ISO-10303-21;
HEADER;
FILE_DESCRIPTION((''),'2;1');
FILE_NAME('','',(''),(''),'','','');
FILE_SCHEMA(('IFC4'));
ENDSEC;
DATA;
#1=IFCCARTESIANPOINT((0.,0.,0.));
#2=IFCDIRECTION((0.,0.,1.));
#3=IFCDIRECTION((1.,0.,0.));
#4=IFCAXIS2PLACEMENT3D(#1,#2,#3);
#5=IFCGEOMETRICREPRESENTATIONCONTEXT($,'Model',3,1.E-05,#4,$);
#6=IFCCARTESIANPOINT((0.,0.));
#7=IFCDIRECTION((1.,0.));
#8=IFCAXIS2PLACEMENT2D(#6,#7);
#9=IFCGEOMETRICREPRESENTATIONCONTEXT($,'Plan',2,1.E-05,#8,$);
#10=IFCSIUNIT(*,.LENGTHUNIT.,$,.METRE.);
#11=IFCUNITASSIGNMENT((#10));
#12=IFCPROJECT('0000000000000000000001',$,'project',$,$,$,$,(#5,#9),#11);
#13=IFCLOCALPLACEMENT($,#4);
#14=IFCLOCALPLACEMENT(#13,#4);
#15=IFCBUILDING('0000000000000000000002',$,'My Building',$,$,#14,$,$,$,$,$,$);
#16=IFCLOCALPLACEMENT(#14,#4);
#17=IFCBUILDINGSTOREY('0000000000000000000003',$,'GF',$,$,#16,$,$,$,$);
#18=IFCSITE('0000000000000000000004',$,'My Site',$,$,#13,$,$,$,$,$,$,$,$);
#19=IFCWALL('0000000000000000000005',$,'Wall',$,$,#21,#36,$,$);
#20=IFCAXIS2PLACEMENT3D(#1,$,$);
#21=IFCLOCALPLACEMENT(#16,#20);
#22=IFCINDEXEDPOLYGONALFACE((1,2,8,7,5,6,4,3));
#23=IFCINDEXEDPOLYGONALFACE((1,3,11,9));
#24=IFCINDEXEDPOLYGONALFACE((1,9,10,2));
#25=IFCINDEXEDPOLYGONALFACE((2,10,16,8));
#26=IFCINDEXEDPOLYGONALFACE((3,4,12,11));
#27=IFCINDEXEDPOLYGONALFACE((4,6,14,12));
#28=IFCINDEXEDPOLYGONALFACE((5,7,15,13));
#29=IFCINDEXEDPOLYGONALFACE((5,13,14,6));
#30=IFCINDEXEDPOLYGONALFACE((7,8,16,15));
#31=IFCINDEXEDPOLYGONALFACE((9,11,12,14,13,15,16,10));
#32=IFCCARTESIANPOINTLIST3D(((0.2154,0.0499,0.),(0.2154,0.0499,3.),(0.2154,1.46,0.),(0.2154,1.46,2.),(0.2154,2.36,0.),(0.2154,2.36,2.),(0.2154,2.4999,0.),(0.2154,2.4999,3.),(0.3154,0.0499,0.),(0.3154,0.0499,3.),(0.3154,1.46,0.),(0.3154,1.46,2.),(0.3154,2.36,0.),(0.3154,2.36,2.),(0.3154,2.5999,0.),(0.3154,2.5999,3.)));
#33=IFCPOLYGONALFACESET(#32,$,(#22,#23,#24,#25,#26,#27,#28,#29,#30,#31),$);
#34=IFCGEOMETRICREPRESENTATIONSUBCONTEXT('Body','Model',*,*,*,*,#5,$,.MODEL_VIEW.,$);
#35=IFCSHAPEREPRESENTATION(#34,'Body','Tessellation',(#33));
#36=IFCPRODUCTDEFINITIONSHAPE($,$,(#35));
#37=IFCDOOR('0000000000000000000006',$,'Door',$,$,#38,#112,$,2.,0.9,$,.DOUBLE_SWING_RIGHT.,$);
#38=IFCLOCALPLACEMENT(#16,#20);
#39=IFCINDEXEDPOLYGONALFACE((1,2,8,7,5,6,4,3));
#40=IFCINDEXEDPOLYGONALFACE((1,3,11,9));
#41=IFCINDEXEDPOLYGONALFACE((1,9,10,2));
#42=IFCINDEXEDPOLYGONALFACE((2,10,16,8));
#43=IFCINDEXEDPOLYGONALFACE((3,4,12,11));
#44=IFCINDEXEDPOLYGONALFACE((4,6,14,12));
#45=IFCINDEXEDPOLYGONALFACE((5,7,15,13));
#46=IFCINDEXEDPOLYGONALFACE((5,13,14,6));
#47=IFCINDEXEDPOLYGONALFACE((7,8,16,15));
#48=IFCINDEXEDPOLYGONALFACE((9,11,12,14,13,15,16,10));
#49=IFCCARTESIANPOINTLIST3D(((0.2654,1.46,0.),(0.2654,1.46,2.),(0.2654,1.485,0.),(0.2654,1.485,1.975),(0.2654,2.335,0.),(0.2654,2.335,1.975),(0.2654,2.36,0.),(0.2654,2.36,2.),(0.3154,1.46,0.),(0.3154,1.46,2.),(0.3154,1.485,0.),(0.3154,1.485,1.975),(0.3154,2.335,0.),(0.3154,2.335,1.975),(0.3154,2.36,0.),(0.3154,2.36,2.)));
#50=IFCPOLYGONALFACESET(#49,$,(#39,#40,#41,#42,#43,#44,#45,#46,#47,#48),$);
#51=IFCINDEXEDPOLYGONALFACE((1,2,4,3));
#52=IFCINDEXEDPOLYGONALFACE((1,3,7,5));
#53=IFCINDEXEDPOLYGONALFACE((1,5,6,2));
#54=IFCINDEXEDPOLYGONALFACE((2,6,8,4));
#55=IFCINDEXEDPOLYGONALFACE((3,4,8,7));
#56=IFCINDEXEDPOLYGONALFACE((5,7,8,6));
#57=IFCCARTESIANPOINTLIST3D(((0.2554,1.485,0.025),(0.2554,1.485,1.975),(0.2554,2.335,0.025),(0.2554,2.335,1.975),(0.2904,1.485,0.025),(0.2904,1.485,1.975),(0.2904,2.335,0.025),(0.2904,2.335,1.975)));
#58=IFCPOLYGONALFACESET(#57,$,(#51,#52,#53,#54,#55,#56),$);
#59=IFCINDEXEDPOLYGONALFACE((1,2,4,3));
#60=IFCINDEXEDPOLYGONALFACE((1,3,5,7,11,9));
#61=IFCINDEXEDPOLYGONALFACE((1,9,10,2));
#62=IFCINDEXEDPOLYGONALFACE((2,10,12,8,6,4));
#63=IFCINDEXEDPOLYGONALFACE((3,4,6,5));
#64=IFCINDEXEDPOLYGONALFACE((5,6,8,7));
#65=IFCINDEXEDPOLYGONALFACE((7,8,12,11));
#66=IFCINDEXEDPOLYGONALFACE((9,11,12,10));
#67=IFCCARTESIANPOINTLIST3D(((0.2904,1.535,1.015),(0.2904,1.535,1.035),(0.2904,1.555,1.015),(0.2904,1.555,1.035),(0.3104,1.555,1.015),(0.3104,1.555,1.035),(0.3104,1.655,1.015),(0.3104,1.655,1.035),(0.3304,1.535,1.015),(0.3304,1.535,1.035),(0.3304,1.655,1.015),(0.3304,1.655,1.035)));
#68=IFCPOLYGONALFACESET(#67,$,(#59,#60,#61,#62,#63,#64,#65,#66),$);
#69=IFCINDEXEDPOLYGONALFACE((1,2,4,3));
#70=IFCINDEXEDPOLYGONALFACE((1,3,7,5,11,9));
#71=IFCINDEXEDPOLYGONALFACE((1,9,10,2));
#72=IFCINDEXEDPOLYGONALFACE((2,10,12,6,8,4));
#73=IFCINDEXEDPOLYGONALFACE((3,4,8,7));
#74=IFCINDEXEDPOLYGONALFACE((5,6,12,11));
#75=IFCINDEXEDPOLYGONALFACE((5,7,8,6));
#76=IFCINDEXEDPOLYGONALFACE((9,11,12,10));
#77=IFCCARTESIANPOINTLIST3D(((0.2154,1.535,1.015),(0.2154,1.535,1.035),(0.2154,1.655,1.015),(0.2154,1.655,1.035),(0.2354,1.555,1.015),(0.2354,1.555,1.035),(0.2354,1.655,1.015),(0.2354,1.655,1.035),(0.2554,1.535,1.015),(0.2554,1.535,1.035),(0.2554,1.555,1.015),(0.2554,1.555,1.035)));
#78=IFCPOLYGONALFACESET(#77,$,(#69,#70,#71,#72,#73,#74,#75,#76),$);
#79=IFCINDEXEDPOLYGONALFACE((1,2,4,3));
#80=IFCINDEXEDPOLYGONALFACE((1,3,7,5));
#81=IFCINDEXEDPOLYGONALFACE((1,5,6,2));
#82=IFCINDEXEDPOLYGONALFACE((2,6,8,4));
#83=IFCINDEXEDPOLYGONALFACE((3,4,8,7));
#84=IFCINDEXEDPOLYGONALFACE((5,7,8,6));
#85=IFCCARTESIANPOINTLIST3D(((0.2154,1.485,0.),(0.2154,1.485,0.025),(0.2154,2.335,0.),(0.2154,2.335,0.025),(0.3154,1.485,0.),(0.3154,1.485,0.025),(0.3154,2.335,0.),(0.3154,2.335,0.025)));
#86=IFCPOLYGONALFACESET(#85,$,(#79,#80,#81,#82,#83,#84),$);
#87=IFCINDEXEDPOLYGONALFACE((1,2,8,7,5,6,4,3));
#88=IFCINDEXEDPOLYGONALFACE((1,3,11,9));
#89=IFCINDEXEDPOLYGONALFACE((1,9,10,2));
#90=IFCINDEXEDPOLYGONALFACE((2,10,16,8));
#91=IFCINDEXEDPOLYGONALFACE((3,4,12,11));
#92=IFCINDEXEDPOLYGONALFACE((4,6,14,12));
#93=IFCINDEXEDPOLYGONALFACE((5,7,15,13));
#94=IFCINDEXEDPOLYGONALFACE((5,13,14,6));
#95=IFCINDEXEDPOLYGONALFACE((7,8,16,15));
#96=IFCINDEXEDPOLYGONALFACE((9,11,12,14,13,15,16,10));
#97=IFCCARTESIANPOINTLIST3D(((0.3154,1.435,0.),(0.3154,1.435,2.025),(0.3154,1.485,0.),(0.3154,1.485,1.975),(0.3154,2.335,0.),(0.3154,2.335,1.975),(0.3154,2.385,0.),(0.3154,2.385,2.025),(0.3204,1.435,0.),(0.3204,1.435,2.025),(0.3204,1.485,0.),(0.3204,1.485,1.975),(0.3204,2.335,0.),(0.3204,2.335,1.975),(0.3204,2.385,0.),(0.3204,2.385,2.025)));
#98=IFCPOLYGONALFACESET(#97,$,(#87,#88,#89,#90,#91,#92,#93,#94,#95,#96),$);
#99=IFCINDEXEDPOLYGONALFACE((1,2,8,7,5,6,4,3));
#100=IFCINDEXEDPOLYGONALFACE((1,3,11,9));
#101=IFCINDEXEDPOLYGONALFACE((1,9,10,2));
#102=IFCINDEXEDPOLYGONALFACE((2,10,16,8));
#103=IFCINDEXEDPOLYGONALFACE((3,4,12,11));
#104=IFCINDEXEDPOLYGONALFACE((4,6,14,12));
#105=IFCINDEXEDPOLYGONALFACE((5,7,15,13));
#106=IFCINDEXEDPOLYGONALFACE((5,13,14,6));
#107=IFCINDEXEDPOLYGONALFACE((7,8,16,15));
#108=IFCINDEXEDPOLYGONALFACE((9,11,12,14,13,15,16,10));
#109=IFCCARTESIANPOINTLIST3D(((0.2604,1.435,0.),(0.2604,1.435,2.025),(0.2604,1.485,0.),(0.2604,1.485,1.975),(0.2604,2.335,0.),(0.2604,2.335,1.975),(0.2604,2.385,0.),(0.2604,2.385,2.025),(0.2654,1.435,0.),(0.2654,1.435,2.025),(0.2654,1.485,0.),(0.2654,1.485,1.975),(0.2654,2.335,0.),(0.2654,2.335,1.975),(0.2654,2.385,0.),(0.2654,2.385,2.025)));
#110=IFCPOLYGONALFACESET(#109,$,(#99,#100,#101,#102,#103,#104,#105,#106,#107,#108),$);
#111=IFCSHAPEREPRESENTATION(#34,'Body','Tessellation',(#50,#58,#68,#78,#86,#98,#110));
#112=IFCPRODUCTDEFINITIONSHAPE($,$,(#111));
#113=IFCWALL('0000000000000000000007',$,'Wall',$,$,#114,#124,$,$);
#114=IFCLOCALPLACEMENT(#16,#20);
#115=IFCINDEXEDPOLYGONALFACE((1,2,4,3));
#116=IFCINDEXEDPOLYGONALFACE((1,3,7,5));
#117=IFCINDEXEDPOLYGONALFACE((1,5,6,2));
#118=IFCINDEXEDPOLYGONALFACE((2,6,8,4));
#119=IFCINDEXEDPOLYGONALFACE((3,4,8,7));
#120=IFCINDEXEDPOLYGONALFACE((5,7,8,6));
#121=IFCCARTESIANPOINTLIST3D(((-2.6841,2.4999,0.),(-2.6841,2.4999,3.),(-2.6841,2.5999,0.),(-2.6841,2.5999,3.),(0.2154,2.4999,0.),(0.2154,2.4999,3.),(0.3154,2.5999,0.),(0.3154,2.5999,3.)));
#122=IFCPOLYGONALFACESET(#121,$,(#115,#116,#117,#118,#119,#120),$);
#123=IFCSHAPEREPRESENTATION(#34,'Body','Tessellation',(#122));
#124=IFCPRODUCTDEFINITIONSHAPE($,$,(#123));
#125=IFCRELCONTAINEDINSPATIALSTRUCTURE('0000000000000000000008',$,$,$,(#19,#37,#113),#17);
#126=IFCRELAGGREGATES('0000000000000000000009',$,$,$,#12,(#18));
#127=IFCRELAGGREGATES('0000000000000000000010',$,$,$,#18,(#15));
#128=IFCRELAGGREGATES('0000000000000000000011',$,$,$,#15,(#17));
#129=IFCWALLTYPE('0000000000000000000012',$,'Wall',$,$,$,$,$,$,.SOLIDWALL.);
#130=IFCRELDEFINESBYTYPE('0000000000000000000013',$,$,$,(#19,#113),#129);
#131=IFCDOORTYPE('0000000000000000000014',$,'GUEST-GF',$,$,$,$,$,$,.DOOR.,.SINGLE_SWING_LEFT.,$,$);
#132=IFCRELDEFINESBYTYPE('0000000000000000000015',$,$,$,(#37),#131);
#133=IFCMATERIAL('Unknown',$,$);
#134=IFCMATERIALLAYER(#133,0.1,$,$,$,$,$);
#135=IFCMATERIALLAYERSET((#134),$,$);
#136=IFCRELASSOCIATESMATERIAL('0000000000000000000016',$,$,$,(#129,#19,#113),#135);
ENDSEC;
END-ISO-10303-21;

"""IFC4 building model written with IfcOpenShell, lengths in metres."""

from ifc_helpers import new_model, entity, si_unit, frame, origin_with_axes, origin_2d_with_axis, place, context, subcontext, project, spatial, line, indexed_curve, outline, extrude, shape, source, transform, mapped, material, layer, layer_set, layer_usage, type_object, type_shapes, element, fill, save


model = new_model("IFC4")

# Units and contexts
model_context = context("Model", 3, precision=1e-05, world=origin_with_axes())
plan_context = context("Plan", 2, precision=1e-05, world=origin_2d_with_axis())
body_context_1 = subcontext(model_context, "Body", "Model", "MODEL_VIEW")
body_context_2 = subcontext(plan_context, "Body", "Plan", "PLAN_VIEW")
ifc_project = project(units=[si_unit("LENGTHUNIT", "METRE")], contexts=[model_context, plan_context])

# Site, building, storey
site_placement = place(None, origin_with_axes())
site = spatial("IfcSite", under=ifc_project, at=site_placement, Name="My Site")
building_placement = place(site_placement, origin_with_axes())
building = spatial("IfcBuilding", under=site, at=building_placement, Name="My Building")
storey_placement = place(building_placement, origin_with_axes())
storey = spatial("IfcBuildingStorey", under=building, at=storey_placement, Name="GF")

# Shared definitions
ifc_material_1 = material(Name="Unknown")

# Shared definitions
ifc_layer_1 = layer(ifc_material_1, 0.1)
ifc_layer_set_1 = layer_set([ifc_layer_1])
wall_type = type_object("IfcWallType", Name="Wall", PredefinedType="SOLIDWALL", material=ifc_layer_set_1)

# Wall, opening, door
ifc_layer_usage_1 = layer_usage(ifc_layer_set_1, "AXIS2", "POSITIVE", 0.0)
wall_1_placement = place(storey_placement, frame((0.3154, 0.0499, 0.0), z_axis=(0.0, 0.0, 1.0), x_axis=(0.0, 1.0, 0.0)))
wall_1 = element("IfcWall", 1, at=wall_1_placement, inside=storey, type_object=wall_type, material=ifc_layer_usage_1, Name="Wall", context=body_context_1, shape_type="SweptSolid", body=[
    extrude(outline(indexed_curve([(0.0, 0.0), (0.0, 0.1), (2.45, 0.1), (2.55, 0.0)], segments=[line(1, 2, 3, 4, 1)])), origin_with_axes(), (0.0, 0.0, 1.0), 3.0),
])
shared_shape_1 = source(origin_with_axes(), body_context_1, "Body", "SweptSolid", [
    extrude(outline(indexed_curve([(0.0, 0.0), (0.9, 0.0), (0.9, 2.0), (0.0, 2.0)], segments=[line(1, 2, 3, 4, 1)])), frame((0.0, -0.6, 0.0), z_axis=(0.0, -1.0, 0.0), x_axis=(1.0, 0.0, 0.0)), (0.0, 0.0, -1.0), 1.2),
])
opening_1_placement = place(wall_1_placement, frame((1.4101, 0.0, 0.0), z_axis=(0.0, 0.0, 1.0), x_axis=(1.0, 0.0, 0.0)))
opening_1 = element("IfcOpeningElement", 2, at=opening_1_placement, cuts=wall_1, PredefinedType="OPENING", context=body_context_1, shape_type="MappedRepresentation", body=[
    mapped(shared_shape_1, transform((0.0, 0.0, 0.0), x_axis=(1.0, 0.0, 0.0), y_axis=(0.0, 1.0, 0.0), z_axis=(0.0, 0.0, 1.0), scale=1.0)),
])
door_type_1 = type_object("IfcDoorType", Name="GUEST-GF", OperationType="SINGLE_SWING_LEFT", PredefinedType="DOOR")
shared_shape_2 = source(origin_with_axes(), body_context_1, "Body", "SweptSolid", [
    extrude(outline(indexed_curve([(0.0, 0.0), (0.0, 2.0), (0.9, 2.0), (0.9, 0.0), (0.875, 0.0), (0.875, 1.975), (0.025, 1.975), (0.025, 0.0)], segments=[line(1, 2, 3, 4, 5, 6, 7, 8, 1)])), frame((0.0, 0.0, 0.0), z_axis=(0.0, -1.0, 0.0), x_axis=(1.0, 0.0, 0.0)), (0.0, 0.0, -1.0), 0.05),
    extrude(outline(indexed_curve([(0.0, 0.0), (0.85, 0.0), (0.85, 0.035), (0.0, 0.035)], segments=[line(1, 2, 3, 4, 1)])), frame((0.025, 0.025, 0.025), z_axis=(0.0, 0.0, 1.0), x_axis=(1.0, 0.0, 0.0)), (0.0, 0.0, 1.0), 1.95),
    extrude(outline(indexed_curve([(0.0, 0.0), (0.0, -0.04), (0.12, -0.04), (0.12, -0.02), (0.02, -0.02), (0.02, 0.0)], segments=[line(1, 2, 3, 4, 5, 6, 1)])), frame((0.075, 0.025, 1.015), z_axis=(0.0, 0.0, 1.0), x_axis=(1.0, 0.0, 0.0)), (0.0, 0.0, 1.0), 0.02),
    extrude(outline(indexed_curve([(0.0, 0.0), (0.0, 0.04), (0.12, 0.04), (0.12, 0.02), (0.02, 0.02), (0.02, 0.0)], segments=[line(1, 2, 3, 4, 5, 6, 1)])), frame((0.075, 0.06, 1.015), z_axis=(0.0, 0.0, 1.0), x_axis=(1.0, 0.0, 0.0)), (0.0, 0.0, 1.0), 0.02),
    extrude(outline(indexed_curve([(0.0, 0.0), (0.85, 0.0), (0.85, 0.1), (0.0, 0.1)], segments=[line(1, 2, 3, 4, 1)])), frame((0.025, 0.0, 0.0), z_axis=(0.0, 0.0, 1.0), x_axis=(1.0, 0.0, 0.0)), (0.0, 0.0, 1.0), 0.025),
    extrude(outline(indexed_curve([(0.0, 0.0), (0.0, 2.025), (0.95, 2.025), (0.95, 0.0), (0.9, 0.0), (0.9, 1.975), (0.05, 1.975), (0.05, 0.0)], segments=[line(1, 2, 3, 4, 5, 6, 7, 8, 1)])), frame((-0.025, -0.005, 0.0), z_axis=(0.0, -1.0, 0.0), x_axis=(1.0, 0.0, 0.0)), (0.0, 0.0, -1.0), 0.005),
    extrude(outline(indexed_curve([(0.0, 0.0), (0.0, 2.025), (0.95, 2.025), (0.95, 0.0), (0.9, 0.0), (0.9, 1.975), (0.05, 1.975), (0.05, 0.0)], segments=[line(1, 2, 3, 4, 5, 6, 7, 8, 1)])), frame((-0.025, 0.05, 0.0), z_axis=(0.0, -1.0, 0.0), x_axis=(1.0, 0.0, 0.0)), (0.0, 0.0, -1.0), 0.005),
])
shared_shape_3 = source(origin_with_axes(), body_context_2, "Body", "Curve2D", [
    entity("IfcIndexedPolyCurve", entity("IfcCartesianPointList2D", [[0.0, 0.0], [0.025, 0.0], [0.025, 0.05], [0.0, 0.05]]), [entity("IfcLineIndex", [1, 2, 3, 4, 1])]),
    entity("IfcIndexedPolyCurve", entity("IfcCartesianPointList2D", [[0.9, 0.0], [0.875, 0.0], [0.875, 0.05], [0.9, 0.05]]), [entity("IfcLineIndex", [1, 2, 3, 4, 1])]),
    entity("IfcIndexedPolyCurve", entity("IfcCartesianPointList2D", [[0.875, 0.05], [0.875, -0.8], [0.84, -0.8]])),
    entity("IfcTrimmedCurve", entity("IfcEllipse", entity("IfcAxis2Placement2D", entity("IfcCartesianPoint", [0.84, 0.05]), entity("IfcDirection", [1.0, 0.0])), 0.815, 0.85), [entity("IfcCartesianPoint", [0.84, 0.9])], [entity("IfcCartesianPoint", [0.84, -0.8])], True, "CARTESIAN"),
    entity("IfcIndexedPolyCurve", entity("IfcCartesianPointList2D", [[0.875, 0.05], [0.84, 0.05], [0.84, 0.9], [0.875, 0.9]]), [entity("IfcLineIndex", [1, 2, 3, 4, 1])]),
])
type_shapes(door_type_1, [shared_shape_2, shared_shape_3])
door_1_placement = place(opening_1_placement, frame((0.0, 0.0, 0.0), z_axis=(0.0, 0.0, 1.0), x_axis=(1.0, 0.0, 0.0)))
door_1 = element("IfcDoor", 3, at=door_1_placement, inside=storey, type_object=door_type_1, Name="Door", OperationType="DOUBLE_SWING_RIGHT", OverallHeight=2.0, OverallWidth=0.9, shapes=[
    shape(body_context_1, "Body", "MappedRepresentation", [mapped(shared_shape_2, transform((0.0, 0.0, 0.0), x_axis=(1.0, 0.0, 0.0), y_axis=(0.0, 1.0, 0.0), z_axis=(0.0, 0.0, 1.0), scale=1.0))]),
    shape(body_context_2, "Body", "MappedRepresentation", [mapped(shared_shape_3, transform((0.0, 0.0, 0.0), x_axis=(1.0, 0.0, 0.0), y_axis=(0.0, 1.0, 0.0), z_axis=(0.0, 0.0, 1.0), scale=1.0))]),
])
fill(opening_1, door_1)

# Wall
ifc_layer_usage_2 = layer_usage(ifc_layer_set_1, "AXIS2", "POSITIVE", 0.0)
wall_2_placement = place(storey_placement, frame((0.3154, 2.5999, 0.0), z_axis=(0.0, 0.0, 1.0), x_axis=(-1.0, 0.0, 0.0)))
element("IfcWall", 4, at=wall_2_placement, inside=storey, type_object=wall_type, material=ifc_layer_usage_2, Name="Wall", context=body_context_1, shape_type="SweptSolid", body=[
    extrude(outline(indexed_curve([(0.0, 0.0), (0.1, 0.1), (2.9996, 0.1), (2.9996, 0.0)], segments=[line(1, 2, 3, 4, 1)])), origin_with_axes(), (0.0, 0.0, 1.0), 3.0),
])

save(model, "model.ifc")
